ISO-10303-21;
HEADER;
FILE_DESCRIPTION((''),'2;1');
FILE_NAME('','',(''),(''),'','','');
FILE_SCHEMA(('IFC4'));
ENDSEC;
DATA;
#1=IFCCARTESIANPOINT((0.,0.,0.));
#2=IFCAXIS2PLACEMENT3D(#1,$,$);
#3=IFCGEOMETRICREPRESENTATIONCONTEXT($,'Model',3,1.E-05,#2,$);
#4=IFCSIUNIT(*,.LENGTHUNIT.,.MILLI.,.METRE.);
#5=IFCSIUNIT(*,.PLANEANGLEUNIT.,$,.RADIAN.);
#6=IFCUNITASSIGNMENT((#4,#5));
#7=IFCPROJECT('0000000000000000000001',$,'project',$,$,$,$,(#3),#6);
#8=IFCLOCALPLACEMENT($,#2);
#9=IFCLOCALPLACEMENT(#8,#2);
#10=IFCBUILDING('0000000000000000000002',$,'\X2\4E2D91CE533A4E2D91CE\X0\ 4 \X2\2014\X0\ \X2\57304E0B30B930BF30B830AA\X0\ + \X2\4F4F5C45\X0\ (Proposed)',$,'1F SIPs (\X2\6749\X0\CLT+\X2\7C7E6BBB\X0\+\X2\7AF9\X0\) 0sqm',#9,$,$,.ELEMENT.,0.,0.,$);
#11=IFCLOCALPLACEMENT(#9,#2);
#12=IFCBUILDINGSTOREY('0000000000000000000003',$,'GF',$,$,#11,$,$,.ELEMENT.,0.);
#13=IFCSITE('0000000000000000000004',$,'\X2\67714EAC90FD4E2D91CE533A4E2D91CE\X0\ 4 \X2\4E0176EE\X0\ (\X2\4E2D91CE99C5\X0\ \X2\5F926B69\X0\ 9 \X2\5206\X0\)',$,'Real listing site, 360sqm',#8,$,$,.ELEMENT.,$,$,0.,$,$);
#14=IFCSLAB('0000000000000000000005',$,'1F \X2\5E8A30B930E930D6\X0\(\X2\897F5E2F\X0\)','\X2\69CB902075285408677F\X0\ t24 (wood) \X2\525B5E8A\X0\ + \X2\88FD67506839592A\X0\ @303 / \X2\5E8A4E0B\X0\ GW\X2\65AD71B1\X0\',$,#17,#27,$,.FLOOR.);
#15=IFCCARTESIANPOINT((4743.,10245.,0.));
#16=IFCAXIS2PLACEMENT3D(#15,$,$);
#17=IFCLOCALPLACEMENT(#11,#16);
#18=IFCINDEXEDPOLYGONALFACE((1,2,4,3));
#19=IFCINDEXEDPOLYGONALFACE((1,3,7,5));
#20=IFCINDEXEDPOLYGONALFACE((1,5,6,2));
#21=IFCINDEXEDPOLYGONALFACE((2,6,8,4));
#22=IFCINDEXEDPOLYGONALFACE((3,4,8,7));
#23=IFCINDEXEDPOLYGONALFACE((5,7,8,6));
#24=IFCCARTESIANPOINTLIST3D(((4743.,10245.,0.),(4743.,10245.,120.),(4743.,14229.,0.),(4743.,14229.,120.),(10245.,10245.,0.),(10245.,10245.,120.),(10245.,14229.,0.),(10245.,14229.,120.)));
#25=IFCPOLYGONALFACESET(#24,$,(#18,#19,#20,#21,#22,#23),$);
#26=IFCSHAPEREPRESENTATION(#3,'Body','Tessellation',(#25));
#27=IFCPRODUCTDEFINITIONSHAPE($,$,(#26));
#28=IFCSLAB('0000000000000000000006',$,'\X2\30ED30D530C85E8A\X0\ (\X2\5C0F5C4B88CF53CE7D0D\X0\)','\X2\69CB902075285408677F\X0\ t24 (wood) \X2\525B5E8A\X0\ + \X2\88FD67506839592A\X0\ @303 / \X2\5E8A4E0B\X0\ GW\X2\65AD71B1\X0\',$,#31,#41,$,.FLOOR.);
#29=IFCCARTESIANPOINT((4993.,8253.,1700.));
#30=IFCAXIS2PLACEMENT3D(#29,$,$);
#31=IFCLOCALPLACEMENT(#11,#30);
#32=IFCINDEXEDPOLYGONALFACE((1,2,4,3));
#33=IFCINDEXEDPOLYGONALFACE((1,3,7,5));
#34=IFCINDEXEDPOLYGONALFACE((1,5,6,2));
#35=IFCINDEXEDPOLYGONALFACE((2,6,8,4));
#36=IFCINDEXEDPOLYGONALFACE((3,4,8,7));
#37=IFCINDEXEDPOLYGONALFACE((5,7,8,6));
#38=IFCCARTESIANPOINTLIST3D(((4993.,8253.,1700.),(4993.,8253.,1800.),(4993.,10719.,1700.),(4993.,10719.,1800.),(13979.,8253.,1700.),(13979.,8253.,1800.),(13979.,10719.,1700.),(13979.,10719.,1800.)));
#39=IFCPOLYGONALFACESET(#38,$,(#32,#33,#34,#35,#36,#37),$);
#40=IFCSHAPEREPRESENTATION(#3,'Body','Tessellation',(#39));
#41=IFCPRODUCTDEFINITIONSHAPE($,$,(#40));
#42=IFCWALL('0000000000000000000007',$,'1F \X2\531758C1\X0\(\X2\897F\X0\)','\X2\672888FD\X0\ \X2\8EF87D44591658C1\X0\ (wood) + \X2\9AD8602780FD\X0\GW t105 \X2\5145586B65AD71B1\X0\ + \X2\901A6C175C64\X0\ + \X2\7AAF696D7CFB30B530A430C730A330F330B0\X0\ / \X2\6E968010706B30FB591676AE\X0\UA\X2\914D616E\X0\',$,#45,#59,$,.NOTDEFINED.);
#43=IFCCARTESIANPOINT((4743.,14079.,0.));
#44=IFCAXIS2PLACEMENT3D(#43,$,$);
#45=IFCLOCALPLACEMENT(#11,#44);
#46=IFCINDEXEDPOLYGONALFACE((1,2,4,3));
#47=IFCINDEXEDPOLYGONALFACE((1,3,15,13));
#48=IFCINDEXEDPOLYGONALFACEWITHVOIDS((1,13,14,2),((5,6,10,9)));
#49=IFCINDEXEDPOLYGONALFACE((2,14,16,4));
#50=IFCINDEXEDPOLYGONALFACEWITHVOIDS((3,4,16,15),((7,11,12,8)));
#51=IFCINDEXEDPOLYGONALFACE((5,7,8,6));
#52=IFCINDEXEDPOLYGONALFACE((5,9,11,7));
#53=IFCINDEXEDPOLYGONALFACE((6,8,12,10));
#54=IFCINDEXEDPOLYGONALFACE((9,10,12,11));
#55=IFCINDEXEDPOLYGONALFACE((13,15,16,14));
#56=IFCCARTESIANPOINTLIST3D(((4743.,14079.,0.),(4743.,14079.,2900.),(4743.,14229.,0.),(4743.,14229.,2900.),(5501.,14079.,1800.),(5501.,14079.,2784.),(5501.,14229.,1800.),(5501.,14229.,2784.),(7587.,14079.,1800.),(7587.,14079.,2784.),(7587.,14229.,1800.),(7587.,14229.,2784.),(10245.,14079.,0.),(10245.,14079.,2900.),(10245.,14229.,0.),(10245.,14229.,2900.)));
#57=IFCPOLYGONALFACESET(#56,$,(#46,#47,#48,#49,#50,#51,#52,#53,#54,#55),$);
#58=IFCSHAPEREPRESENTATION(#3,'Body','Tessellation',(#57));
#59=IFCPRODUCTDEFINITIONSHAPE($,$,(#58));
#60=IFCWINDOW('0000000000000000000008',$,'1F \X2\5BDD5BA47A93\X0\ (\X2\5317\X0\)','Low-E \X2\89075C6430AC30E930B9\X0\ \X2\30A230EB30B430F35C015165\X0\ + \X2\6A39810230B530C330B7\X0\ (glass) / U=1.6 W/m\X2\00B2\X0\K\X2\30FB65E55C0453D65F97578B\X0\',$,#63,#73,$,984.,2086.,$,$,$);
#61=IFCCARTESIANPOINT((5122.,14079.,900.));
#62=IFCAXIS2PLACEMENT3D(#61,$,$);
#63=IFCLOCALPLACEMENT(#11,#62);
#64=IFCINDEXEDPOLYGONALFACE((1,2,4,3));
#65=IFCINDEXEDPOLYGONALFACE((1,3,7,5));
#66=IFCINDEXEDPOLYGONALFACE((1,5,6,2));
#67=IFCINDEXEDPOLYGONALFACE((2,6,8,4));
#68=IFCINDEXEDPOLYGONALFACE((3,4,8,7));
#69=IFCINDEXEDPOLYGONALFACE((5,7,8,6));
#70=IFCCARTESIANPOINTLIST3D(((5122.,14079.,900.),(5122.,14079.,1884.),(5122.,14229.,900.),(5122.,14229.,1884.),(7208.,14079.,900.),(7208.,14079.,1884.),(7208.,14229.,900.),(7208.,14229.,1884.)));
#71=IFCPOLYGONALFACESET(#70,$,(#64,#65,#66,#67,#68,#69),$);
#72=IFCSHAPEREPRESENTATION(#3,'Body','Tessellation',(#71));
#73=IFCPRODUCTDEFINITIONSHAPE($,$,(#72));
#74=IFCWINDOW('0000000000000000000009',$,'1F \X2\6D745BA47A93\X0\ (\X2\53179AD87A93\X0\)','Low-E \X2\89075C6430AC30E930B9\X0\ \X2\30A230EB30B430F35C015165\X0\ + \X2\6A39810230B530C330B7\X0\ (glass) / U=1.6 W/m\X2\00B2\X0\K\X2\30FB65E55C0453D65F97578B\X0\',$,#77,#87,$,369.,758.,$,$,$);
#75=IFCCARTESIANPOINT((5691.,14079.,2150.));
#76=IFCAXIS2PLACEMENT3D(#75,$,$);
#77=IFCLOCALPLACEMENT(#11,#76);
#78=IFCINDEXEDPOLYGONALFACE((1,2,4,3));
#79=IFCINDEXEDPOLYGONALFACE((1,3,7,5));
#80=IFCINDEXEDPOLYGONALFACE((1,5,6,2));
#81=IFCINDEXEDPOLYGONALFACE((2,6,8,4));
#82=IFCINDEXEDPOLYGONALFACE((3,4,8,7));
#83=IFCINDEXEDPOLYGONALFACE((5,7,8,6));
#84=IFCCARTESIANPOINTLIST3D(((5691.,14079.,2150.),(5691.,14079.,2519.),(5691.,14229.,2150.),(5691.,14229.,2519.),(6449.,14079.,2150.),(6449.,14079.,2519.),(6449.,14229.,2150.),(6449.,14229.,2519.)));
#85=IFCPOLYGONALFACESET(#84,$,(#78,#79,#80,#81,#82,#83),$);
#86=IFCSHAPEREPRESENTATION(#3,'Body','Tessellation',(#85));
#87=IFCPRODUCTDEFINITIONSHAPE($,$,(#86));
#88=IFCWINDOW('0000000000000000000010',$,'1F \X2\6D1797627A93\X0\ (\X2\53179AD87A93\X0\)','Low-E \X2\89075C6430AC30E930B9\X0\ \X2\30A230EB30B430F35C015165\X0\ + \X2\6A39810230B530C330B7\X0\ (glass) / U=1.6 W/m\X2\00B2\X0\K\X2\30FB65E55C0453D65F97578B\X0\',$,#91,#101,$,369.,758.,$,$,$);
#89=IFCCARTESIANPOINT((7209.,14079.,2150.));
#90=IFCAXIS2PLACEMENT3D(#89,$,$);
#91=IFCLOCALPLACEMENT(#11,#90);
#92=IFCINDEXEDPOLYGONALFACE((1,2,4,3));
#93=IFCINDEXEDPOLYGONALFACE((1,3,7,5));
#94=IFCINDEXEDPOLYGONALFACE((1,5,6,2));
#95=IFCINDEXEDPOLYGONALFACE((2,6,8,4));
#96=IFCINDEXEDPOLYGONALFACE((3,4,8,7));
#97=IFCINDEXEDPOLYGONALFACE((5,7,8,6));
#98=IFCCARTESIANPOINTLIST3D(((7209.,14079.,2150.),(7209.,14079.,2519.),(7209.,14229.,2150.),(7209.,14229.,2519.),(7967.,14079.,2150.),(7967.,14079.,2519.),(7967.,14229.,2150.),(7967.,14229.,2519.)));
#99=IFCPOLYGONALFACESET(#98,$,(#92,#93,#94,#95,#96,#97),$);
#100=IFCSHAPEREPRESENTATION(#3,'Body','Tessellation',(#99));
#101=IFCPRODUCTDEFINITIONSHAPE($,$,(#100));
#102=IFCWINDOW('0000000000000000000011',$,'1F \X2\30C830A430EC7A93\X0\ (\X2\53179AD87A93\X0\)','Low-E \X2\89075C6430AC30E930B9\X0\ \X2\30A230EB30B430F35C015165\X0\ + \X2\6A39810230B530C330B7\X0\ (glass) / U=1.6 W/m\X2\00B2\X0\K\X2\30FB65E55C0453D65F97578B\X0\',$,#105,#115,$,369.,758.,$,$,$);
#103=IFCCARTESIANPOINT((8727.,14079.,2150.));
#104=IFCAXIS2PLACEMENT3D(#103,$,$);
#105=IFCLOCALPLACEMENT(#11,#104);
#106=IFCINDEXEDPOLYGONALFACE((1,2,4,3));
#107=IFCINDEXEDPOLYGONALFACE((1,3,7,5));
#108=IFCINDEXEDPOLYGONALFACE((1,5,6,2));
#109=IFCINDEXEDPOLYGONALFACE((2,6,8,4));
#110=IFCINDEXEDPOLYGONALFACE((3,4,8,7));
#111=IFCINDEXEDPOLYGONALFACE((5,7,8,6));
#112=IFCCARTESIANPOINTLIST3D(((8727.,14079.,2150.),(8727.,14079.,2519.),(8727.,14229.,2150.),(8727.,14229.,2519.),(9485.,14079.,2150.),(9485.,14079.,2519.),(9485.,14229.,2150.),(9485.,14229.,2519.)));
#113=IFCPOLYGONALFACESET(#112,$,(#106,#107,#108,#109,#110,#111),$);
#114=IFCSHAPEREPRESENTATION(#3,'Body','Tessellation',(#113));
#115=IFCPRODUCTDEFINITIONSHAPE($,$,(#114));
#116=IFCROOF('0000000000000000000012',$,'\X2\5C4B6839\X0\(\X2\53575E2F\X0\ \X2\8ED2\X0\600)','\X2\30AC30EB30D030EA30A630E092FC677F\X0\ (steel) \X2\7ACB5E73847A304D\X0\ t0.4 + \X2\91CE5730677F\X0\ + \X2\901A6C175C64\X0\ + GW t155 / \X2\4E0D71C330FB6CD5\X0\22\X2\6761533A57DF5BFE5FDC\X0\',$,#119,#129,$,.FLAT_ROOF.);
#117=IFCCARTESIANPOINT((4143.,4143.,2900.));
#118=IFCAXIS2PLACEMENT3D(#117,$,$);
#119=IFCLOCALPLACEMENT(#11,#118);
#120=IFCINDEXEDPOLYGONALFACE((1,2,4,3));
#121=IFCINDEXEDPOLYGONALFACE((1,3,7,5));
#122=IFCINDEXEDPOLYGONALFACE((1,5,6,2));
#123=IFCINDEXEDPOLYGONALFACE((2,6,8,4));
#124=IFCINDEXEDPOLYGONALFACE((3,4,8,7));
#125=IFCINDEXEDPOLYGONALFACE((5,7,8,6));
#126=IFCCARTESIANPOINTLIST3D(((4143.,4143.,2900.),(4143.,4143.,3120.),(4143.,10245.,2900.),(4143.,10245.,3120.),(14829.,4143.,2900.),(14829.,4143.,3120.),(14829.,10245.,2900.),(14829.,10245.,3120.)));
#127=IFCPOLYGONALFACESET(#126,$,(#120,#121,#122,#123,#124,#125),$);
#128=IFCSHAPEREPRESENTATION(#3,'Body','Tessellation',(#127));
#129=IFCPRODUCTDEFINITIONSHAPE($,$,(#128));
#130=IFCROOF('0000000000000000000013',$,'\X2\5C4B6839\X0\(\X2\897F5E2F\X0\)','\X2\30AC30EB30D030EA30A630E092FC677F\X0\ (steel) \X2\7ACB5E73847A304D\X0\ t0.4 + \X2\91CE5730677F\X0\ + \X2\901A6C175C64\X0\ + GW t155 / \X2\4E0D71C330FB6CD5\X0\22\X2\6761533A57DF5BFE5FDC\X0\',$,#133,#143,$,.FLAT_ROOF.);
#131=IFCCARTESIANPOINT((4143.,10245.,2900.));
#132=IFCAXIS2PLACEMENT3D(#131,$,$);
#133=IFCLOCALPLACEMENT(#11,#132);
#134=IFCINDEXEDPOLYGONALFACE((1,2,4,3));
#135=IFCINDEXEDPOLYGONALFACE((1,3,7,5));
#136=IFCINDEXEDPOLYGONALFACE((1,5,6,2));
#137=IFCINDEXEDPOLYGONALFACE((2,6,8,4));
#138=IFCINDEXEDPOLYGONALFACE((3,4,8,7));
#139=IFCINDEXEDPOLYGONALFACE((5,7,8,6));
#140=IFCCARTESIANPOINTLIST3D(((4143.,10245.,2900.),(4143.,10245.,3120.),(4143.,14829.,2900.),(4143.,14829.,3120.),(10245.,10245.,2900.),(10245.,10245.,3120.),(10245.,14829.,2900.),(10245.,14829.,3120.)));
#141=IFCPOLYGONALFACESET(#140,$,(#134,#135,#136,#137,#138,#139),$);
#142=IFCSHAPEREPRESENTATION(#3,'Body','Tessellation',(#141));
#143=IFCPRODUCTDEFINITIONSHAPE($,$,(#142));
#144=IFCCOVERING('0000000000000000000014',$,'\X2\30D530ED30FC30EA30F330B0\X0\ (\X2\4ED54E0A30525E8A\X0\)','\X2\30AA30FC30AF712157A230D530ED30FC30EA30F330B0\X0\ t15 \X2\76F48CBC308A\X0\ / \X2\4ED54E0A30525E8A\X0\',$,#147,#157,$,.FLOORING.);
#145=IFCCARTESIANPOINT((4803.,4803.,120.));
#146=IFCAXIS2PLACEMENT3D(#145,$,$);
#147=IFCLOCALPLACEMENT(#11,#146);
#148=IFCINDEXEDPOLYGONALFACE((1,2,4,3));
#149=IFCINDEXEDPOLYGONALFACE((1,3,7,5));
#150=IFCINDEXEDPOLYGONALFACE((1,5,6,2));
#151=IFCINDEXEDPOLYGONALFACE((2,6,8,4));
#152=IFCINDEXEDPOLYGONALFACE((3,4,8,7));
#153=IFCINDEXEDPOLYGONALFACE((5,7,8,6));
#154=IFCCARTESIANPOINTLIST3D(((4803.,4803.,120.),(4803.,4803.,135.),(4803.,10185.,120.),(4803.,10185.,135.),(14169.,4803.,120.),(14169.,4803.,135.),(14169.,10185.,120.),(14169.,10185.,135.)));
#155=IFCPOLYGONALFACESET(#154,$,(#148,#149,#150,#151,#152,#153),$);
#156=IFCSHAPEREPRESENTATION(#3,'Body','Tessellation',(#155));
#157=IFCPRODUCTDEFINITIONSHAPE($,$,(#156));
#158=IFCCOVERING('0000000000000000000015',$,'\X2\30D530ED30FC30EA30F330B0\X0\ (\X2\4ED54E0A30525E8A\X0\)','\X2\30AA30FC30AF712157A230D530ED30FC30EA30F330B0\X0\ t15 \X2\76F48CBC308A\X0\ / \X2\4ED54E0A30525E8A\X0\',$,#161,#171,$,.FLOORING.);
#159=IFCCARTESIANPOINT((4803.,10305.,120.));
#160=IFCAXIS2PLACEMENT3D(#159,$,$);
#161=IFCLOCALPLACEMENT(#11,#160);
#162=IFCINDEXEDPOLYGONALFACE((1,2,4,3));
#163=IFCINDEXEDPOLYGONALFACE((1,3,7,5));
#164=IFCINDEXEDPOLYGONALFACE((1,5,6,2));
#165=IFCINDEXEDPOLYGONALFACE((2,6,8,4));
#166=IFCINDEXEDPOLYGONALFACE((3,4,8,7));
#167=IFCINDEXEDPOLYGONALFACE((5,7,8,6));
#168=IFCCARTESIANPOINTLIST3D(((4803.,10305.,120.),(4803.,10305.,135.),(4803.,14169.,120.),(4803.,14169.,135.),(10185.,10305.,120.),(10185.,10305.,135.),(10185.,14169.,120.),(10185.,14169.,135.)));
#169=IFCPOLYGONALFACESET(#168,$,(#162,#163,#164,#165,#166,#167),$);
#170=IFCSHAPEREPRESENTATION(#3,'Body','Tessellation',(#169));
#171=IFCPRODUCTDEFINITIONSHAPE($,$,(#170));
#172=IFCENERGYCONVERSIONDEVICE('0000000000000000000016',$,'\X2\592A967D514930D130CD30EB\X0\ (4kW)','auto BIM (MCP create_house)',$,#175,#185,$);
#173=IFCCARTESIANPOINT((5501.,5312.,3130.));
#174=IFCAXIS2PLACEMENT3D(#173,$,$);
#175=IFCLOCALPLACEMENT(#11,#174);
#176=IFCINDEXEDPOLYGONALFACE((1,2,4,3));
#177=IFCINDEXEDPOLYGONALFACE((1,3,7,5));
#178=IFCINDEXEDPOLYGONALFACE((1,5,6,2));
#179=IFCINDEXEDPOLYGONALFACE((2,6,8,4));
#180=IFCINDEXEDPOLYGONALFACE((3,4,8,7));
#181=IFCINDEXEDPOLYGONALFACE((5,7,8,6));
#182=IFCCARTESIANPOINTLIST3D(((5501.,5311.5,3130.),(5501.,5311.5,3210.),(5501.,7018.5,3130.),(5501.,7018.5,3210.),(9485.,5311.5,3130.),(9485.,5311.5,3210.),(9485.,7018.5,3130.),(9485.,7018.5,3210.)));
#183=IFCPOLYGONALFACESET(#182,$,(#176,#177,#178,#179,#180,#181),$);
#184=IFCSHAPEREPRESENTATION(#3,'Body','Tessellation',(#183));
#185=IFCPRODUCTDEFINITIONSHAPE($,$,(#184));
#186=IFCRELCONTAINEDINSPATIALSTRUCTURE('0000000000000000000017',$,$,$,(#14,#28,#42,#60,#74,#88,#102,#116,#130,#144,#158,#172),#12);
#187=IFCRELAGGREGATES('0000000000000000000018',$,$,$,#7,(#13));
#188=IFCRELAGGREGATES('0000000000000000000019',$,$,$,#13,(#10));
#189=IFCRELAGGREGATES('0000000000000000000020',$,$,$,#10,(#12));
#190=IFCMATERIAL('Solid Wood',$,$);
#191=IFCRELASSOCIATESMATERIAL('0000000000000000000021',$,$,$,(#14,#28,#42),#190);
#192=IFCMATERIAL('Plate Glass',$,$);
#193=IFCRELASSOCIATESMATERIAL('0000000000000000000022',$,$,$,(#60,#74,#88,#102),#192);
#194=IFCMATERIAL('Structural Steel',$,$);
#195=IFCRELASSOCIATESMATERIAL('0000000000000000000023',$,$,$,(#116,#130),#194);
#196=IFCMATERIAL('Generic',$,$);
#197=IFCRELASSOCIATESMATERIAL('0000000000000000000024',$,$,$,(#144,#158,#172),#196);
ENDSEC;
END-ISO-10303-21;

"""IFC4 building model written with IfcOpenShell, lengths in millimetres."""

from ifc_helpers import new_model, si_unit, frame, frame_2d, origin, place, context, project, spatial, rectangle, extrude, material, element, fill, save


model = new_model("IFC4")

# Units and contexts
model_context = context("Model", 3, precision=1e-05, world=origin())
ifc_project = project(units=[si_unit("LENGTHUNIT", "METRE", prefix="MILLI"), si_unit("PLANEANGLEUNIT", "RADIAN")], contexts=[model_context])

# Site, building, storey
site_placement = place(None, origin())
site = spatial("IfcSite", under=ifc_project, at=site_placement, Name="東京都中野区中野 4 丁目 (中野駅 徒歩 9 分)", ObjectType="Real listing site, 360sqm", CompositionType="ELEMENT", RefElevation=0.0)
building_placement = place(site_placement, origin())
building = spatial("IfcBuilding", under=site, at=building_placement, Name="中野区中野 4 — 地下スタジオ + 住居 (Proposed)", ObjectType="1F SIPs (杉CLT+籾殻+竹) 0sqm", CompositionType="ELEMENT", ElevationOfRefHeight=0.0, ElevationOfTerrain=0.0)
storey_placement = place(building_placement, origin())
storey = spatial("IfcBuildingStorey", under=building, at=storey_placement, Name="GF", CompositionType="ELEMENT", Elevation=0.0)

# Slabs
ifc_material_1 = material(Name="Solid Wood")
slab_1_placement = place(storey_placement, frame((4743.0, 10245.0, 0.0)))
element("IfcSlab", 1, at=slab_1_placement, inside=storey, material=ifc_material_1, Name="1F 床スラブ(西帯)", Description="構造用合板 t24 (wood) 剛床 + 製材根太 @303 / 床下 GW断熱", PredefinedType="FLOOR", context=model_context, shape_type="SweptSolid", body=[
    extrude(rectangle(XDim=5502.0, YDim=3984.0, at=frame_2d((2751.0, 1992.0))), frame((4743.0, 10245.0, 0.0)), (0.0, 0.0, 1.0), 120.0),
])
slab_2_placement = place(storey_placement, frame((4993.0, 8253.0, 1700.0)))
element("IfcSlab", 2, at=slab_2_placement, inside=storey, material=ifc_material_1, Name="ロフト床 (小屋裏収納)", Description="構造用合板 t24 (wood) 剛床 + 製材根太 @303 / 床下 GW断熱", PredefinedType="FLOOR", context=model_context, shape_type="SweptSolid", body=[
    extrude(rectangle(XDim=8986.0, YDim=2466.0, at=frame_2d((4493.0, 1233.0))), frame((4993.0, 8253.0, 1700.0)), (0.0, 0.0, 1.0), 100.0),
])

# Shared definitions
ifc_material_2 = material(Name="Plate Glass")

# Wall, openings, windows
wall_1_placement = place(storey_placement, frame((4743.0, 14079.0, 0.0)))
wall_1 = element("IfcWall", 3, at=wall_1_placement, inside=storey, material=ifc_material_1, Name="1F 北壁(西)", Description="木製 軸組外壁 (wood) + 高性能GW t105 充填断熱 + 通気層 + 窯業系サイディング / 準耐火・外皮UA配慮", PredefinedType="NOTDEFINED", context=model_context, shape_type="SweptSolid", body=[
    extrude(rectangle(XDim=5502.0, YDim=150.0, at=frame_2d((2751.0, 75.0))), frame((4743.0, 14079.0, 0.0)), (0.0, 0.0, 1.0), 2900.0),
])
opening_1_placement = place(storey_placement, frame((5122.0, 14079.0, 900.0)))
opening_1 = element("IfcOpeningElement", 4, at=opening_1_placement, cuts=wall_1, PredefinedType="NOTDEFINED", context=model_context, shape_type="SweptSolid", body=[
    extrude(rectangle(XDim=2086.0, YDim=150.0, at=frame_2d((1043.0, 75.0))), frame((5122.0, 14079.0, 900.0)), (0.0, 0.0, 1.0), 984.0),
])
opening_2_placement = place(storey_placement, frame((5691.0, 14079.0, 2150.0)))
opening_2 = element("IfcOpeningElement", 5, at=opening_2_placement, cuts=wall_1, PredefinedType="NOTDEFINED", context=model_context, shape_type="SweptSolid", body=[
    extrude(rectangle(XDim=758.0, YDim=150.0, at=frame_2d((379.0, 75.0))), frame((5691.0, 14079.0, 2150.0)), (0.0, 0.0, 1.0), 369.0),
])
opening_3_placement = place(storey_placement, frame((7209.0, 14079.0, 2150.0)))
opening_3 = element("IfcOpeningElement", 6, at=opening_3_placement, cuts=wall_1, PredefinedType="NOTDEFINED", context=model_context, shape_type="SweptSolid", body=[
    extrude(rectangle(XDim=758.0, YDim=150.0, at=frame_2d((379.0, 75.0))), frame((7209.0, 14079.0, 2150.0)), (0.0, 0.0, 1.0), 369.0),
])
opening_4_placement = place(storey_placement, frame((8727.0, 14079.0, 2150.0)))
opening_4 = element("IfcOpeningElement", 7, at=opening_4_placement, cuts=wall_1, PredefinedType="NOTDEFINED", context=model_context, shape_type="SweptSolid", body=[
    extrude(rectangle(XDim=758.0, YDim=150.0, at=frame_2d((379.0, 75.0))), frame((8727.0, 14079.0, 2150.0)), (0.0, 0.0, 1.0), 369.0),
])
window_1_placement = place(storey_placement, frame((5122.0, 14079.0, 900.0)))
window_1 = element("IfcWindow", 8, at=window_1_placement, inside=storey, material=ifc_material_2, Name="1F 寝室窓 (北)", Description="Low-E 複層ガラス アルゴン封入 + 樹脂サッシ (glass) / U=1.6 W/m²K・日射取得型", OverallHeight=984.0, OverallWidth=2086.0, context=model_context, shape_type="SweptSolid", body=[
    extrude(rectangle(XDim=2086.0, YDim=150.0, at=frame_2d((1043.0, 75.0))), frame((5122.0, 14079.0, 900.0)), (0.0, 0.0, 1.0), 984.0),
])
fill(opening_1, window_1)
window_2_placement = place(storey_placement, frame((5691.0, 14079.0, 2150.0)))
window_2 = element("IfcWindow", 9, at=window_2_placement, inside=storey, material=ifc_material_2, Name="1F 浴室窓 (北高窓)", Description="Low-E 複層ガラス アルゴン封入 + 樹脂サッシ (glass) / U=1.6 W/m²K・日射取得型", OverallHeight=369.0, OverallWidth=758.0, context=model_context, shape_type="SweptSolid", body=[
    extrude(rectangle(XDim=758.0, YDim=150.0, at=frame_2d((379.0, 75.0))), frame((5691.0, 14079.0, 2150.0)), (0.0, 0.0, 1.0), 369.0),
])
fill(opening_2, window_2)
window_3_placement = place(storey_placement, frame((7209.0, 14079.0, 2150.0)))
window_3 = element("IfcWindow", 10, at=window_3_placement, inside=storey, material=ifc_material_2, Name="1F 洗面窓 (北高窓)", Description="Low-E 複層ガラス アルゴン封入 + 樹脂サッシ (glass) / U=1.6 W/m²K・日射取得型", OverallHeight=369.0, OverallWidth=758.0, context=model_context, shape_type="SweptSolid", body=[
    extrude(rectangle(XDim=758.0, YDim=150.0, at=frame_2d((379.0, 75.0))), frame((7209.0, 14079.0, 2150.0)), (0.0, 0.0, 1.0), 369.0),
])
fill(opening_3, window_3)
window_4_placement = place(storey_placement, frame((8727.0, 14079.0, 2150.0)))
window_4 = element("IfcWindow", 11, at=window_4_placement, inside=storey, material=ifc_material_2, Name="1F トイレ窓 (北高窓)", Description="Low-E 複層ガラス アルゴン封入 + 樹脂サッシ (glass) / U=1.6 W/m²K・日射取得型", OverallHeight=369.0, OverallWidth=758.0, context=model_context, shape_type="SweptSolid", body=[
    extrude(rectangle(XDim=758.0, YDim=150.0, at=frame_2d((379.0, 75.0))), frame((8727.0, 14079.0, 2150.0)), (0.0, 0.0, 1.0), 369.0),
])
fill(opening_4, window_4)

# Roofs
ifc_material_3 = material(Name="Structural Steel")
roof_1_placement = place(storey_placement, frame((4143.0, 4143.0, 2900.0)))
element("IfcRoof", 12, at=roof_1_placement, inside=storey, material=ifc_material_3, Name="屋根(南帯 軒600)", Description="ガルバリウム鋼板 (steel) 立平葺き t0.4 + 野地板 + 通気層 + GW t155 / 不燃・法22条区域対応", PredefinedType="FLAT_ROOF", context=model_context, shape_type="SweptSolid", body=[
    extrude(rectangle(XDim=10686.0, YDim=6102.0, at=frame_2d((5343.0, 3051.0))), frame((4143.0, 4143.0, 2900.0)), (0.0, 0.0, 1.0), 220.0),
])
roof_2_placement = place(storey_placement, frame((4143.0, 10245.0, 2900.0)))
element("IfcRoof", 13, at=roof_2_placement, inside=storey, material=ifc_material_3, Name="屋根(西帯)", Description="ガルバリウム鋼板 (steel) 立平葺き t0.4 + 野地板 + 通気層 + GW t155 / 不燃・法22条区域対応", PredefinedType="FLAT_ROOF", context=model_context, shape_type="SweptSolid", body=[
    extrude(rectangle(XDim=6102.0, YDim=4584.0, at=frame_2d((3051.0, 2292.0))), frame((4143.0, 10245.0, 2900.0)), (0.0, 0.0, 1.0), 220.0),
])

# Coverings
ifc_material_4 = material(Name="Generic")
covering_1_placement = place(storey_placement, frame((4803.0, 4803.0, 120.0)))
element("IfcCovering", 14, at=covering_1_placement, inside=storey, material=ifc_material_4, Name="フローリング (仕上げ床)", Description="オーク無垢フローリング t15 直貼り / 仕上げ床", PredefinedType="FLOORING", context=model_context, shape_type="SweptSolid", body=[
    extrude(rectangle(XDim=9366.0, YDim=5382.0, at=frame_2d((4683.0, 2691.0))), frame((4803.0, 4803.0, 120.0)), (0.0, 0.0, 1.0), 15.0),
])
covering_2_placement = place(storey_placement, frame((4803.0, 10305.0, 120.0)))
element("IfcCovering", 15, at=covering_2_placement, inside=storey, material=ifc_material_4, Name="フローリング (仕上げ床)", Description="オーク無垢フローリング t15 直貼り / 仕上げ床", PredefinedType="FLOORING", context=model_context, shape_type="SweptSolid", body=[
    extrude(rectangle(XDim=5382.0, YDim=3864.0, at=frame_2d((2691.0, 1932.0))), frame((4803.0, 10305.0, 120.0)), (0.0, 0.0, 1.0), 15.0),
])

# Energy conversion device
energy_conversion_device_placement = place(storey_placement, frame((5501.0, 5312.0, 3130.0)))
element("IfcEnergyConversionDevice", 16, at=energy_conversion_device_placement, inside=storey, material=ifc_material_4, Name="太陽光パネル (4kW)", Description="auto BIM (MCP create_house)", context=model_context, shape_type="SweptSolid", body=[
    extrude(rectangle(XDim=3984.0, YDim=1707.0, at=frame_2d((1992.0, 853.0))), frame((5501.0, 5312.0, 3130.0)), (0.0, 0.0, 1.0), 80.0),
])

save(model, "model.ifc")
